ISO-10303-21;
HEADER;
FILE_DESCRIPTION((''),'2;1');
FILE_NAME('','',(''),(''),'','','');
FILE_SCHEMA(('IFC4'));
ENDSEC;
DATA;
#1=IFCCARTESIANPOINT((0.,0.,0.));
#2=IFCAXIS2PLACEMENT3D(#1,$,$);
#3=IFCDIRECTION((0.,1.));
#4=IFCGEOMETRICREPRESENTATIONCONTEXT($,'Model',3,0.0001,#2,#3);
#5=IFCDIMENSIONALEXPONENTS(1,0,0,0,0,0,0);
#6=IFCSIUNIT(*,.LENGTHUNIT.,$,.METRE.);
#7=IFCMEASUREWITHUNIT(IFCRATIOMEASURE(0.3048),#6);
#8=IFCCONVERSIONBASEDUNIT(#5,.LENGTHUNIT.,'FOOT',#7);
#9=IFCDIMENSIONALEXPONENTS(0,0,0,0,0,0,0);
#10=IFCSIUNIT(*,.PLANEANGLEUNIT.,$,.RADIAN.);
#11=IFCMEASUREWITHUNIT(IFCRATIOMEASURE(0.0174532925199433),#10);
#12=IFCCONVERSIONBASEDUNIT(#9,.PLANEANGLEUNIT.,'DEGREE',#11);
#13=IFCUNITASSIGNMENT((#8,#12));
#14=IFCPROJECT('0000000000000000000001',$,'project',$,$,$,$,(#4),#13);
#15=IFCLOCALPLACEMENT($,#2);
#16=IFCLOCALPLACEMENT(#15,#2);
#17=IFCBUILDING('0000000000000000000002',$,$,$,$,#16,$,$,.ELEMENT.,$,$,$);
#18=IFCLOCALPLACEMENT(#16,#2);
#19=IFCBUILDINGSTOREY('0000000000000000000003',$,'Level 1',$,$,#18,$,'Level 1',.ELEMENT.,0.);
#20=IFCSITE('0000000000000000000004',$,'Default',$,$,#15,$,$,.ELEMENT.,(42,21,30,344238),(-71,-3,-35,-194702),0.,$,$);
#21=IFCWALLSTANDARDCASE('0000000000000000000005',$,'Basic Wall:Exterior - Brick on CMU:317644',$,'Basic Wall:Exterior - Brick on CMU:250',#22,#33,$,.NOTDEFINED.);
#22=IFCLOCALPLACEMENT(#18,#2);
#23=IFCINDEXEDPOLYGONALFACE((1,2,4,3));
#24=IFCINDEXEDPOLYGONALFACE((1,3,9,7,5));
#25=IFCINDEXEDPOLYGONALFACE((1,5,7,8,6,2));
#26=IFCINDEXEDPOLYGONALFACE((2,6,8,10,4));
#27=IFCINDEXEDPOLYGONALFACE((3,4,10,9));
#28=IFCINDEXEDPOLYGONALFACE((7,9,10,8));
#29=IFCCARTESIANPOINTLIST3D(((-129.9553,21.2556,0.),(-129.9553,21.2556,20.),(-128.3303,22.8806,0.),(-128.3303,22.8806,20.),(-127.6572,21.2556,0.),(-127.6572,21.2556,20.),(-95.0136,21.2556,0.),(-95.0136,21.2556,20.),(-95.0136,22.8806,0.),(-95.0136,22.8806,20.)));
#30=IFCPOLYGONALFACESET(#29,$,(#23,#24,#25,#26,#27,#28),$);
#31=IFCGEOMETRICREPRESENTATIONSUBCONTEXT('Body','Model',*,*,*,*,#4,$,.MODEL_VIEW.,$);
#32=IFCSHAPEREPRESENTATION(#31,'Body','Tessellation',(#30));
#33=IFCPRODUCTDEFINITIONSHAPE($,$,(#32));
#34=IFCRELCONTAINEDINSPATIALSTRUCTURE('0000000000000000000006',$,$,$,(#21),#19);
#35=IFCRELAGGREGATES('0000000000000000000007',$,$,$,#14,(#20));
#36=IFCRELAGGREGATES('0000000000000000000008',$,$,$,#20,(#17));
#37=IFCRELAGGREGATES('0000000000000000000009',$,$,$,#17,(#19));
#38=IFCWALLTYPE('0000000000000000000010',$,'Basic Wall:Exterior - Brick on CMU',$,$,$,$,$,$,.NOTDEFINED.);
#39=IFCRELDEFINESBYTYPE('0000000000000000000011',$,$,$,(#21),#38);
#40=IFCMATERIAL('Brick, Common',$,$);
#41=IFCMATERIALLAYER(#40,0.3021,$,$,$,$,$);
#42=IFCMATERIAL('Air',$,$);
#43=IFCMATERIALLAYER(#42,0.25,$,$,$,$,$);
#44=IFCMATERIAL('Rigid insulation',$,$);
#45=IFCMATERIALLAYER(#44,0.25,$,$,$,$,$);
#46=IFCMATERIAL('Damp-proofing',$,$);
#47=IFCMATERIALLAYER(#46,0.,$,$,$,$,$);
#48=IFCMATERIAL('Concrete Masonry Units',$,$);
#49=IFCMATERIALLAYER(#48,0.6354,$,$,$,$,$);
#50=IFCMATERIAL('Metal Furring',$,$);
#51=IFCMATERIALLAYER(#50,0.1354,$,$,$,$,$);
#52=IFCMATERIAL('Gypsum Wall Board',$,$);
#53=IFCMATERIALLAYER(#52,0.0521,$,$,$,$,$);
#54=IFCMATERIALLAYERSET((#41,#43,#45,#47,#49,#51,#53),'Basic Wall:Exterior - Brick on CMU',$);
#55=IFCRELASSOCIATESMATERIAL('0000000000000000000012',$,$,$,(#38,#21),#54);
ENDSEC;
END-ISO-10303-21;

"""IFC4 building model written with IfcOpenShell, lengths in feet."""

from ifc_helpers import new_model, entity, si_unit, converted_unit, direction, frame, origin, place, context, subcontext, project, spatial, polyline, outline, extrude, material, layer, layer_set, layer_usage, type_object, element, save


model = new_model("IFC4")

# Units and contexts
model_context = context("Model", 3, precision=0.0001, world=origin(), true_north=direction((0.0, 1.0)))
body_context = subcontext(model_context, "Body", "Model", "MODEL_VIEW")
ifc_project = project(units=[converted_unit("LENGTHUNIT", "FOOT", entity("IfcRatioMeasure", 0.3048), si_unit("LENGTHUNIT", "METRE"), dimensions=[1, 0, 0, 0, 0, 0, 0]), converted_unit("PLANEANGLEUNIT", "DEGREE", entity("IfcRatioMeasure", 0.0174532925199433), si_unit("PLANEANGLEUNIT", "RADIAN"), dimensions=[0, 0, 0, 0, 0, 0, 0])], contexts=[model_context])

# Site, building, storey
site_placement = place(None, origin())
site = spatial("IfcSite", under=ifc_project, at=site_placement, Name="Default", CompositionType="ELEMENT", RefLatitude=(42, 21, 30, 344238), RefLongitude=(-71, -3, -35, -194702), RefElevation=0.0)
building_placement = place(site_placement, origin())
building = spatial("IfcBuilding", under=site, at=building_placement, CompositionType="ELEMENT")
storey_placement = place(building_placement, origin())
storey = spatial("IfcBuildingStorey", under=building, at=storey_placement, Name="Level 1", LongName="Level 1", CompositionType="ELEMENT", Elevation=0.0)

# Wall
ifc_material_1 = material(Name="Brick, Common")
ifc_layer_1 = layer(ifc_material_1, 0.3021)
ifc_material_2 = material(Name="Air")
ifc_layer_2 = layer(ifc_material_2, 0.25)
ifc_material_3 = material(Name="Rigid insulation")
ifc_layer_3 = layer(ifc_material_3, 0.25)
ifc_material_4 = material(Name="Damp-proofing")
ifc_layer_4 = layer(ifc_material_4, 0.0)
ifc_material_5 = material(Name="Concrete Masonry Units")
ifc_layer_5 = layer(ifc_material_5, 0.6354)
ifc_material_6 = material(Name="Metal Furring")
ifc_layer_6 = layer(ifc_material_6, 0.1354)
ifc_material_7 = material(Name="Gypsum Wall Board")
ifc_layer_7 = layer(ifc_material_7, 0.0521)
ifc_layer_set = layer_set([ifc_layer_1, ifc_layer_2, ifc_layer_3, ifc_layer_4, ifc_layer_5, ifc_layer_6, ifc_layer_7], Name="Basic Wall:Exterior - Brick on CMU")
ifc_layer_usage = layer_usage(ifc_layer_set, "AXIS2", "NEGATIVE", 0.8125)
wall_type = type_object("IfcWallType", Name="Basic Wall:Exterior - Brick on CMU", PredefinedType="NOTDEFINED", material=ifc_layer_set)
wall_placement = place(storey_placement, frame((-95.0136, 22.0681, 0.0), z_axis=(0.0, 0.0, 1.0), x_axis=(-1.0, 0.0, 0.0)))
element("IfcWallStandardCase", 1, at=wall_placement, inside=storey, type_object=wall_type, material=ifc_layer_usage, Name="Basic Wall:Exterior - Brick on CMU:317644", ObjectType="Basic Wall:Exterior - Brick on CMU:250", PredefinedType="NOTDEFINED", context=body_context, shape_type="SweptSolid", body=[
    extrude(outline(polyline([(33.3167, -0.8125), (34.9417, 0.8125), (32.6436, 0.8125), (0.0, 0.8125), (0.0, -0.8125), (33.3167, -0.8125)])), origin(), (0.0, 0.0, 1.0), 20.0),
])

save(model, "model.ifc")
